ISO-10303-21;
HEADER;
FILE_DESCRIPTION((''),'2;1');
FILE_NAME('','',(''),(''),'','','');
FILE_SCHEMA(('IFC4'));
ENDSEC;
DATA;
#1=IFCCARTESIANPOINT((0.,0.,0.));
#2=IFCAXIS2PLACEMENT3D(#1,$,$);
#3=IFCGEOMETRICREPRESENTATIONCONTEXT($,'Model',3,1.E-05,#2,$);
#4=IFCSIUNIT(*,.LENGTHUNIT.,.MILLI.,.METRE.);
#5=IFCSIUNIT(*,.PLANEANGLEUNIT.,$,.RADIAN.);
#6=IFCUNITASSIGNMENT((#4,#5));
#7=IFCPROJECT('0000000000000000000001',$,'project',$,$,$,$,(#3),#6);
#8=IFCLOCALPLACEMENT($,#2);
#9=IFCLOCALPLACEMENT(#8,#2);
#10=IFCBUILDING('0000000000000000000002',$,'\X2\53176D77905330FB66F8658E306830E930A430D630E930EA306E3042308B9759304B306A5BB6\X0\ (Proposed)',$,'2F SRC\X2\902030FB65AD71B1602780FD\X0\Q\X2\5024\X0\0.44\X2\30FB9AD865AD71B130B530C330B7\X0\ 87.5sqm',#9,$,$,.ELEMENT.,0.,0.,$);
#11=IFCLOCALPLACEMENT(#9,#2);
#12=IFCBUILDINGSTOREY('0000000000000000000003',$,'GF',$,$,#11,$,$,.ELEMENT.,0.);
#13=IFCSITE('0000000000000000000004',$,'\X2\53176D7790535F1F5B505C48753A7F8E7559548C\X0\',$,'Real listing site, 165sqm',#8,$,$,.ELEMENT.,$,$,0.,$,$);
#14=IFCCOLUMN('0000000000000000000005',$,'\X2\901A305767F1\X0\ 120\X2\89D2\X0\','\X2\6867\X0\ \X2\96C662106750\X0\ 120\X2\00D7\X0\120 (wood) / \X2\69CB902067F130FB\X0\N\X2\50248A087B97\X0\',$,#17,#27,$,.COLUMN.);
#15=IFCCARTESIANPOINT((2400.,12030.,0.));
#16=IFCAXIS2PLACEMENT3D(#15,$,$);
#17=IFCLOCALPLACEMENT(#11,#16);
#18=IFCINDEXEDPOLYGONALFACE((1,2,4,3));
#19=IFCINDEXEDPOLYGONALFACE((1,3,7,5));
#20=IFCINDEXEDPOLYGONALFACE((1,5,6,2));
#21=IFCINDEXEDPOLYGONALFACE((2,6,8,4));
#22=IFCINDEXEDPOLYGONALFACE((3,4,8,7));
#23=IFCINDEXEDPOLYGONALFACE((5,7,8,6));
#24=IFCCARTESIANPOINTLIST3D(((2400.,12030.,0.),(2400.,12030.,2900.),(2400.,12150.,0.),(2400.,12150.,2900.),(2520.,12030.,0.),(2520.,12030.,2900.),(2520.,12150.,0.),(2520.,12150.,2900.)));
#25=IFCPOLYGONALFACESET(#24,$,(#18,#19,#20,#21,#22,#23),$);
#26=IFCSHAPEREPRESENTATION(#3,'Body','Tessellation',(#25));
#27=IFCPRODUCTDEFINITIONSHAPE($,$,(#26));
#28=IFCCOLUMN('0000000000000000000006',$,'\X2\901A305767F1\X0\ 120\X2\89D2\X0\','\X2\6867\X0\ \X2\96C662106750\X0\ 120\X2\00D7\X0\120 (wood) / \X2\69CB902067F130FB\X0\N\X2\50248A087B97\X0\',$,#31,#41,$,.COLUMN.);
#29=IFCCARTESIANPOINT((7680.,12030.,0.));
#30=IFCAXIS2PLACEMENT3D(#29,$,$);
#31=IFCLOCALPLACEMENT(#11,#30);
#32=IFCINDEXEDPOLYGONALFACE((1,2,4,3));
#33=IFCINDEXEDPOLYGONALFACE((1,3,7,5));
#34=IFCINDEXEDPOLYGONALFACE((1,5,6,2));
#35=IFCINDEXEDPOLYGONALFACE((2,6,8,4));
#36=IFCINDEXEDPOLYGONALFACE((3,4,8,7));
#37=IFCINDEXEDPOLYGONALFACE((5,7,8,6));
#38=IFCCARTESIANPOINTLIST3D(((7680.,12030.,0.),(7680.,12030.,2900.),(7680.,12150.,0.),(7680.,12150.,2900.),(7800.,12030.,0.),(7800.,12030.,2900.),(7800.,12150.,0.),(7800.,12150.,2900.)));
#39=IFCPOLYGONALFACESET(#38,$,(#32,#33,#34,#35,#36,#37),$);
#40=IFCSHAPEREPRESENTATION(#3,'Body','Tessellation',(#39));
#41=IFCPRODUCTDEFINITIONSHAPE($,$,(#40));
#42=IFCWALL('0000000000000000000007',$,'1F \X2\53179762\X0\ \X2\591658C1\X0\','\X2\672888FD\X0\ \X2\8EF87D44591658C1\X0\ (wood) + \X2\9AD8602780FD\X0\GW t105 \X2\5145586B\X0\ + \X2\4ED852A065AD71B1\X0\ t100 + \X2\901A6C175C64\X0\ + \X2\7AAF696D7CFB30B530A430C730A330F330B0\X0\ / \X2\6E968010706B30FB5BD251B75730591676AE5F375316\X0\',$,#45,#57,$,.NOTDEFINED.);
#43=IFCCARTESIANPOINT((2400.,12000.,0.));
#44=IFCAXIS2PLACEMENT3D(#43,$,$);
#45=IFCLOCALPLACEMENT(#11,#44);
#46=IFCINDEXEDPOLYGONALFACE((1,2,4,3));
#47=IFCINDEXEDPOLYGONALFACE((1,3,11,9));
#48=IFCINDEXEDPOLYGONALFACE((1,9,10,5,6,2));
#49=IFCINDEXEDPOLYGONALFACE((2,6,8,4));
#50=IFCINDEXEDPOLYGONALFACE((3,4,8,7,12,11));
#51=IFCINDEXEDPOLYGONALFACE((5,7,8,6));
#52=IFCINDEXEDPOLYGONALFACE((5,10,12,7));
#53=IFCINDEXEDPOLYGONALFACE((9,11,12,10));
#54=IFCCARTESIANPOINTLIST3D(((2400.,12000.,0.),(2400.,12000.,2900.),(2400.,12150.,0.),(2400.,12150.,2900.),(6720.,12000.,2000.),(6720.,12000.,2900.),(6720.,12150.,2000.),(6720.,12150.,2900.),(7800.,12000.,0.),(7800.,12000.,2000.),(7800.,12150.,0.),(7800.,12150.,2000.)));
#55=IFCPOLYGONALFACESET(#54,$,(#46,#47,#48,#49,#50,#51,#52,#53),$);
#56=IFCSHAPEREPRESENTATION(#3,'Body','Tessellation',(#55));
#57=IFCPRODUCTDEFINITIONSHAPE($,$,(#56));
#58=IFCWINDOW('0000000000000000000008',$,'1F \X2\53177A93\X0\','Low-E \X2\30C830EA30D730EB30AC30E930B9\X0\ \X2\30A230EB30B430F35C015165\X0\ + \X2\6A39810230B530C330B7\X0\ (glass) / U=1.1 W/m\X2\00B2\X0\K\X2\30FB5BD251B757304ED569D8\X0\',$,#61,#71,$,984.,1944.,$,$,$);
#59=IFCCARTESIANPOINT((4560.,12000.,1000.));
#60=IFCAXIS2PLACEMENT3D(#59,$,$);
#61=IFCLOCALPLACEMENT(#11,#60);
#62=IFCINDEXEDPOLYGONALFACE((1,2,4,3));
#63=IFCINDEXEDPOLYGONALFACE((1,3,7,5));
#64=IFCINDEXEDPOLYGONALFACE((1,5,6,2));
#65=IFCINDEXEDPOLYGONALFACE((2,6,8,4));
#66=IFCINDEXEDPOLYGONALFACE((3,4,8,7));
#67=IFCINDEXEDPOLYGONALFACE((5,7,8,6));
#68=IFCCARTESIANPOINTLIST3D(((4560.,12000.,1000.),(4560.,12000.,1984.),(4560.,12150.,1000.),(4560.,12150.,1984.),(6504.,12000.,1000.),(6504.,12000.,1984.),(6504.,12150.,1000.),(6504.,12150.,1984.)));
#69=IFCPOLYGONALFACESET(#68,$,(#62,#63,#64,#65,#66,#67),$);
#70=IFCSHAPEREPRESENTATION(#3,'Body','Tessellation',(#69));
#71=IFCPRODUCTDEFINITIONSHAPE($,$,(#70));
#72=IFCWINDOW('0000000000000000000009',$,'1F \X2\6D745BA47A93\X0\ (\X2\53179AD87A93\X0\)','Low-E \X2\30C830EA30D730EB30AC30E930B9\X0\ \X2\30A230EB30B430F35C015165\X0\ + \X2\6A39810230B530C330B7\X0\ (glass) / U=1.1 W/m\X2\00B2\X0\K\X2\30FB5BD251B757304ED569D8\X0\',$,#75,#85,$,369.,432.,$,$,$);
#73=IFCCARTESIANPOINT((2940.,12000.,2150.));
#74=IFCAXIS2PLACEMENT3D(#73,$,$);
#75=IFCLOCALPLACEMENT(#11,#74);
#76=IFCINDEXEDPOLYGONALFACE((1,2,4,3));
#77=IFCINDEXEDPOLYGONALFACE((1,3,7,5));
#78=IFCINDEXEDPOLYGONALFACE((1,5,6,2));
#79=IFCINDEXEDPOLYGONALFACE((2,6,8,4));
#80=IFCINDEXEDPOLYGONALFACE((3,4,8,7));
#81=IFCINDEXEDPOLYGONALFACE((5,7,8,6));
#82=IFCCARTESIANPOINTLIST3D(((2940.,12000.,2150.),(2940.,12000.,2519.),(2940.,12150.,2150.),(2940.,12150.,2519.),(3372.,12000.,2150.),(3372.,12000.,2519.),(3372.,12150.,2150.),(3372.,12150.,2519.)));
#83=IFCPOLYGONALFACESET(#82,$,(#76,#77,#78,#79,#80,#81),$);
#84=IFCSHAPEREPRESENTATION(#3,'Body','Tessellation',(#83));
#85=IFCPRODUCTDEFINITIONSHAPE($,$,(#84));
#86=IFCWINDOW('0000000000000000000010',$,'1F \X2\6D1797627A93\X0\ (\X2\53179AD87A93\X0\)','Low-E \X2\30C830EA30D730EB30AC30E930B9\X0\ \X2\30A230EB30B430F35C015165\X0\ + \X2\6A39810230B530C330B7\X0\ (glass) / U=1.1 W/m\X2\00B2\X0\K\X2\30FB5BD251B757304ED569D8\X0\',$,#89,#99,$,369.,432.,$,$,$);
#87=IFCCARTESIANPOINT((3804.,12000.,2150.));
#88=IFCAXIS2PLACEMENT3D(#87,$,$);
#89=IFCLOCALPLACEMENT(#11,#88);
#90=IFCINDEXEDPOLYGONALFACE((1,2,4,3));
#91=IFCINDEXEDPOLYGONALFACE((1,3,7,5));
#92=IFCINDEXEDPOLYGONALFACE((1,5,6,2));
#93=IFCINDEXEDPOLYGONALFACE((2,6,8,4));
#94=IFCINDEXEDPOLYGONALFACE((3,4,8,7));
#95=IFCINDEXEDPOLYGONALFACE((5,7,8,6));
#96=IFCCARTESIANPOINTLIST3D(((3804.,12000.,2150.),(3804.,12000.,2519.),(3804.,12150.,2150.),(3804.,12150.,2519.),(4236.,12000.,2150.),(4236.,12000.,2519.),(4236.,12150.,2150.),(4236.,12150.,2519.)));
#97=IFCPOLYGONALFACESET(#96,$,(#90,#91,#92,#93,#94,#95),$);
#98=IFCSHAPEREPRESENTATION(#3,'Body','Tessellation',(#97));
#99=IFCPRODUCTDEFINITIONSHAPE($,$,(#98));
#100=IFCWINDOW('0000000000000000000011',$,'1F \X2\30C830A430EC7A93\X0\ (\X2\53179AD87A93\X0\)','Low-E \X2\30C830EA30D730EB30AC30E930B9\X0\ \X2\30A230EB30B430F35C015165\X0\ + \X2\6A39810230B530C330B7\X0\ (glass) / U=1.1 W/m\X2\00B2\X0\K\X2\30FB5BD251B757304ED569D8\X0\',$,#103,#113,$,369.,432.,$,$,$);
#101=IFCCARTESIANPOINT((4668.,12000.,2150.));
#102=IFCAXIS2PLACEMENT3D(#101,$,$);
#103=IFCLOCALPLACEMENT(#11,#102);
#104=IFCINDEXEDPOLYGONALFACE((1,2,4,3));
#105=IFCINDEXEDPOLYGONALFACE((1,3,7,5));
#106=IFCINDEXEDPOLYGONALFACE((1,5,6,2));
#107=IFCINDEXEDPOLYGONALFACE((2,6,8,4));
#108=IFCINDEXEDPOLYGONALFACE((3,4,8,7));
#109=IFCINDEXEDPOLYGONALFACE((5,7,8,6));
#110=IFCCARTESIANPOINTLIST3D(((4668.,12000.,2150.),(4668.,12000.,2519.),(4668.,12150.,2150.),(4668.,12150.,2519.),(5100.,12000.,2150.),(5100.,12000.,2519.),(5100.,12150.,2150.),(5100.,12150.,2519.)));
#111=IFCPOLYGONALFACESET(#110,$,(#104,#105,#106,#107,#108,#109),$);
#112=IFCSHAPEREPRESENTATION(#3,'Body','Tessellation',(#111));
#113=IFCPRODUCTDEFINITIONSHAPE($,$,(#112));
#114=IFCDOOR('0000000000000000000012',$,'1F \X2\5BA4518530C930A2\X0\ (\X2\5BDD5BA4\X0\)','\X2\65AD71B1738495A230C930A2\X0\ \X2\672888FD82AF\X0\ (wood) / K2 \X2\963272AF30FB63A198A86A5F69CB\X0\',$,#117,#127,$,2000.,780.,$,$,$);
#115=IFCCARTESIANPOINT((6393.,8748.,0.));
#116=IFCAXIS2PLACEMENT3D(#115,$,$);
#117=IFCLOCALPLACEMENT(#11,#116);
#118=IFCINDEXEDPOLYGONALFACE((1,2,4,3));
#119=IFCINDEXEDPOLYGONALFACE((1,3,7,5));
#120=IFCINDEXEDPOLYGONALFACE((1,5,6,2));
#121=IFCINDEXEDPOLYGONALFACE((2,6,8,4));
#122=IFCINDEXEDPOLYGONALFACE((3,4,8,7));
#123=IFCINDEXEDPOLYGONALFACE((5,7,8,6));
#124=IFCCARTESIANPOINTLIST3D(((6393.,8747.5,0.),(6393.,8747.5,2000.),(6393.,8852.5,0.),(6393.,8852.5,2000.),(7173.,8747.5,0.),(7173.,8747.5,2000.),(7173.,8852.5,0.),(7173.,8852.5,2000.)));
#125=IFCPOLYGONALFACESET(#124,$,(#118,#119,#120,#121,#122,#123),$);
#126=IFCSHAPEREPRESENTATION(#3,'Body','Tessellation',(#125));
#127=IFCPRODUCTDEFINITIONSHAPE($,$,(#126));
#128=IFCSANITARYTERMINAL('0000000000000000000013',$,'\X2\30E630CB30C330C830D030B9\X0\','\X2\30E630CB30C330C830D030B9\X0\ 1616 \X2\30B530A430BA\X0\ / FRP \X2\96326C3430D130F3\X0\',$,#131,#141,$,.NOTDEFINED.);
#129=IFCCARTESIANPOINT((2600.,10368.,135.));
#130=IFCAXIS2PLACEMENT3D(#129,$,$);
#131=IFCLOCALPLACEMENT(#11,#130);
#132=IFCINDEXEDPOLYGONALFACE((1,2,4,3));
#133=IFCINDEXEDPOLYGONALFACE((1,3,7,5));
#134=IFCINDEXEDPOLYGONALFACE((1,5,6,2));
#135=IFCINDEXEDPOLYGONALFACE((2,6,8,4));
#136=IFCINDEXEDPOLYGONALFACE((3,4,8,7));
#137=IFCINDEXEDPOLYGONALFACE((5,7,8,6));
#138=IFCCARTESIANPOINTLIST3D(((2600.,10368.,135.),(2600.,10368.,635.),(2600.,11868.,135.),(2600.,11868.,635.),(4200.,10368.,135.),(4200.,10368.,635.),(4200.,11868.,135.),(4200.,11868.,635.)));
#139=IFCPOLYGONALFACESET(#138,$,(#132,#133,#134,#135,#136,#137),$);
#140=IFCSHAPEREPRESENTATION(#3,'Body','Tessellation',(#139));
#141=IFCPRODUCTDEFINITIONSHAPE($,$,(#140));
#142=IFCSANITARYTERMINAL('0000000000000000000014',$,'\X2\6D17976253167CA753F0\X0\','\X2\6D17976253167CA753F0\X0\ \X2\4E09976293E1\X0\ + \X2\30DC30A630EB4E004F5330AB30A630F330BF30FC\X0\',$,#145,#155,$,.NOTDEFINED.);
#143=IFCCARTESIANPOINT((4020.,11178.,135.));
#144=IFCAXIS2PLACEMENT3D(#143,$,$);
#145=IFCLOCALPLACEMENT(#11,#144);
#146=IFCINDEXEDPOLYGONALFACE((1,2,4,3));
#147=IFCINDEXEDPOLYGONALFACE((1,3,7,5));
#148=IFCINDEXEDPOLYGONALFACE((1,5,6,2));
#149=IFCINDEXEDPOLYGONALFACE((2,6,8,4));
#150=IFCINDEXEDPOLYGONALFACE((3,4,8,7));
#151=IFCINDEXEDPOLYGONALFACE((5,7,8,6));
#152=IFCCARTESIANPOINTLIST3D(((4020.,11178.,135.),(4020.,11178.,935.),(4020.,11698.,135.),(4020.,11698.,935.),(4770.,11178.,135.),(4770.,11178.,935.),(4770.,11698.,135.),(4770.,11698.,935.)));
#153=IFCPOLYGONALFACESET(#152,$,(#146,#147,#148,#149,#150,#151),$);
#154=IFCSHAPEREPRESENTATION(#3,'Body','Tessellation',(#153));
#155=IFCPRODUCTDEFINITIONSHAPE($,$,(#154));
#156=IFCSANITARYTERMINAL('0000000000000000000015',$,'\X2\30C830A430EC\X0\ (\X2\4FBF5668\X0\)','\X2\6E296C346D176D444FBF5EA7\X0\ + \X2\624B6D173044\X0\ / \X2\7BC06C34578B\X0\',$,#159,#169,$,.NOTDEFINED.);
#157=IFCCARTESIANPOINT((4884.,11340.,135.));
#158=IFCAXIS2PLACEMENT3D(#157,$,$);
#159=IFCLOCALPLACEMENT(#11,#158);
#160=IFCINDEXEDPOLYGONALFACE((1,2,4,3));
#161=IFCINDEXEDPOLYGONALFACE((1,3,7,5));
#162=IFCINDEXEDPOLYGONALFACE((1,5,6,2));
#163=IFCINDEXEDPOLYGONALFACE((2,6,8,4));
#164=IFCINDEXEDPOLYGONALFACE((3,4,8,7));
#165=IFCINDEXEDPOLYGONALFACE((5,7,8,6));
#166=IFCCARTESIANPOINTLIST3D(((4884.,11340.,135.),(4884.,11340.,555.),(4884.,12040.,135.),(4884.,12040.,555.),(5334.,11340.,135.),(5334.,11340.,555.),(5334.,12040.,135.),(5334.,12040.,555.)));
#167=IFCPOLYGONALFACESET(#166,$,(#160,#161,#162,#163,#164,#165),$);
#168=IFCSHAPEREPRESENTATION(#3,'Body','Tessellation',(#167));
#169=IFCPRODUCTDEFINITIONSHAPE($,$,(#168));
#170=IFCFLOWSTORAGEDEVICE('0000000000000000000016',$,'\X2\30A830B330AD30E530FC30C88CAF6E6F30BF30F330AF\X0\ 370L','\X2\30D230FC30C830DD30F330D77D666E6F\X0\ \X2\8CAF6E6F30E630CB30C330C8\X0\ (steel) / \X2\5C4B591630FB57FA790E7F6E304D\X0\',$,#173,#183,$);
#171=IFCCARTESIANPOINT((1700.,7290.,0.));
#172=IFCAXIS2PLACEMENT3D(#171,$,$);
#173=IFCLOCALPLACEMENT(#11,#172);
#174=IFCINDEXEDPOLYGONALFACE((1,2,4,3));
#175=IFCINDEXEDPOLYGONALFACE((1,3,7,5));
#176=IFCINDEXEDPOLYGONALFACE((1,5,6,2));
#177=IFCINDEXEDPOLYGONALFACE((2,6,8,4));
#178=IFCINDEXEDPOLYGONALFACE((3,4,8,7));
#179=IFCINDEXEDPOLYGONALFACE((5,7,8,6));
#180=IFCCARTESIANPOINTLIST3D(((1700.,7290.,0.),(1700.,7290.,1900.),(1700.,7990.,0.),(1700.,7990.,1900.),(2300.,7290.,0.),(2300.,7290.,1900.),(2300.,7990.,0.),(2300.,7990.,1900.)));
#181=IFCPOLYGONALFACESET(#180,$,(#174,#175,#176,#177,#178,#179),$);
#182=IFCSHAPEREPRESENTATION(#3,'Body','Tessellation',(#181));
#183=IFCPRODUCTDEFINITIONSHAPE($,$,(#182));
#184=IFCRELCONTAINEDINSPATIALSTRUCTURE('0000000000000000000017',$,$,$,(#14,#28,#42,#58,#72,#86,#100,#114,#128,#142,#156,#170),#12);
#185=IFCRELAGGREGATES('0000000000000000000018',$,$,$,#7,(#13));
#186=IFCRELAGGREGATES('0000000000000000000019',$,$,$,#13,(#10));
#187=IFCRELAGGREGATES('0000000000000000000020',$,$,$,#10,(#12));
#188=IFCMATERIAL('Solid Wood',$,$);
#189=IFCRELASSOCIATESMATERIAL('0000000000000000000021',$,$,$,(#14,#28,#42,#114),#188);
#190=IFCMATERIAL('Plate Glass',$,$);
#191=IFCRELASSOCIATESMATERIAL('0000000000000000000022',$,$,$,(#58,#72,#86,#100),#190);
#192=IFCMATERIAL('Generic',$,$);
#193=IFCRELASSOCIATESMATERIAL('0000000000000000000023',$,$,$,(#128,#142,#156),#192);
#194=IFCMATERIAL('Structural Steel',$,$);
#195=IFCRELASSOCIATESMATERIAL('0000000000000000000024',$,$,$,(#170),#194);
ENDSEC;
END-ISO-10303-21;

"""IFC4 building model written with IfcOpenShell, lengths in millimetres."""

from ifc_helpers import new_model, si_unit, frame, frame_2d, origin, place, context, project, spatial, rectangle, extrude, material, element, fill, save


model = new_model("IFC4")

# Units and contexts
model_context = context("Model", 3, precision=1e-05, world=origin())
ifc_project = project(units=[si_unit("LENGTHUNIT", "METRE", prefix="MILLI"), si_unit("PLANEANGLEUNIT", "RADIAN")], contexts=[model_context])

# Site, building, storey
site_placement = place(None, origin())
site = spatial("IfcSite", under=ifc_project, at=site_placement, Name="北海道弟子屈町美留和", ObjectType="Real listing site, 165sqm", CompositionType="ELEMENT", RefElevation=0.0)
building_placement = place(site_placement, origin())
building = spatial("IfcBuilding", under=site, at=building_placement, Name="北海道・書斎とライブラリのある静かな家 (Proposed)", ObjectType="2F SRC造・断熱性能Q値0.44・高断熱サッシ 87.5sqm", CompositionType="ELEMENT", ElevationOfRefHeight=0.0, ElevationOfTerrain=0.0)
storey_placement = place(building_placement, origin())
storey = spatial("IfcBuildingStorey", under=building, at=storey_placement, Name="GF", CompositionType="ELEMENT", Elevation=0.0)

# Columns
ifc_material_1 = material(Name="Solid Wood")
column_1_placement = place(storey_placement, frame((2400.0, 12030.0, 0.0)))
element("IfcColumn", 1, at=column_1_placement, inside=storey, material=ifc_material_1, Name="通し柱 120角", Description="桧 集成材 120×120 (wood) / 構造柱・N値計算", PredefinedType="COLUMN", context=model_context, shape_type="SweptSolid", body=[
    extrude(rectangle(XDim=120.0, YDim=120.0, at=frame_2d((60.0, 60.0))), frame((2400.0, 12030.0, 0.0)), (0.0, 0.0, 1.0), 2900.0),
])
column_2_placement = place(storey_placement, frame((7680.0, 12030.0, 0.0)))
element("IfcColumn", 2, at=column_2_placement, inside=storey, material=ifc_material_1, Name="通し柱 120角", Description="桧 集成材 120×120 (wood) / 構造柱・N値計算", PredefinedType="COLUMN", context=model_context, shape_type="SweptSolid", body=[
    extrude(rectangle(XDim=120.0, YDim=120.0, at=frame_2d((60.0, 60.0))), frame((7680.0, 12030.0, 0.0)), (0.0, 0.0, 1.0), 2900.0),
])

# Wall, openings, windows
wall_1_placement = place(storey_placement, frame((2400.0, 12000.0, 0.0)))
wall_1 = element("IfcWall", 3, at=wall_1_placement, inside=storey, material=ifc_material_1, Name="1F 北面 外壁", Description="木製 軸組外壁 (wood) + 高性能GW t105 充填 + 付加断熱 t100 + 通気層 + 窯業系サイディング / 準耐火・寒冷地外皮強化", PredefinedType="NOTDEFINED", context=model_context, shape_type="SweptSolid", body=[
    extrude(rectangle(XDim=5400.0, YDim=150.0, at=frame_2d((2700.0, 75.0))), frame((2400.0, 12000.0, 0.0)), (0.0, 0.0, 1.0), 2900.0),
])
opening_1_placement = place(storey_placement, frame((4560.0, 12000.0, 1000.0)))
opening_1 = element("IfcOpeningElement", 4, at=opening_1_placement, cuts=wall_1, PredefinedType="NOTDEFINED", context=model_context, shape_type="SweptSolid", body=[
    extrude(rectangle(XDim=1944.0, YDim=150.0, at=frame_2d((972.0, 75.0))), frame((4560.0, 12000.0, 1000.0)), (0.0, 0.0, 1.0), 984.0),
])
opening_2_placement = place(storey_placement, frame((2940.0, 12000.0, 2150.0)))
opening_2 = element("IfcOpeningElement", 5, at=opening_2_placement, cuts=wall_1, PredefinedType="NOTDEFINED", context=model_context, shape_type="SweptSolid", body=[
    extrude(rectangle(XDim=432.0, YDim=150.0, at=frame_2d((216.0, 75.0))), frame((2940.0, 12000.0, 2150.0)), (0.0, 0.0, 1.0), 369.0),
])
opening_3_placement = place(storey_placement, frame((3804.0, 12000.0, 2150.0)))
opening_3 = element("IfcOpeningElement", 6, at=opening_3_placement, cuts=wall_1, PredefinedType="NOTDEFINED", context=model_context, shape_type="SweptSolid", body=[
    extrude(rectangle(XDim=432.0, YDim=150.0, at=frame_2d((216.0, 75.0))), frame((3804.0, 12000.0, 2150.0)), (0.0, 0.0, 1.0), 369.0),
])
opening_4_placement = place(storey_placement, frame((4668.0, 12000.0, 2150.0)))
opening_4 = element("IfcOpeningElement", 7, at=opening_4_placement, cuts=wall_1, PredefinedType="NOTDEFINED", context=model_context, shape_type="SweptSolid", body=[
    extrude(rectangle(XDim=432.0, YDim=150.0, at=frame_2d((216.0, 75.0))), frame((4668.0, 12000.0, 2150.0)), (0.0, 0.0, 1.0), 369.0),
])
ifc_material_2 = material(Name="Plate Glass")
window_1_placement = place(storey_placement, frame((4560.0, 12000.0, 1000.0)))
window_1 = element("IfcWindow", 8, at=window_1_placement, inside=storey, material=ifc_material_2, Name="1F 北窓", Description="Low-E トリプルガラス アルゴン封入 + 樹脂サッシ (glass) / U=1.1 W/m²K・寒冷地仕様", OverallHeight=984.0, OverallWidth=1944.0, context=model_context, shape_type="SweptSolid", body=[
    extrude(rectangle(XDim=1944.0, YDim=150.0, at=frame_2d((972.0, 75.0))), frame((4560.0, 12000.0, 1000.0)), (0.0, 0.0, 1.0), 984.0),
])
fill(opening_1, window_1)
window_2_placement = place(storey_placement, frame((2940.0, 12000.0, 2150.0)))
window_2 = element("IfcWindow", 9, at=window_2_placement, inside=storey, material=ifc_material_2, Name="1F 浴室窓 (北高窓)", Description="Low-E トリプルガラス アルゴン封入 + 樹脂サッシ (glass) / U=1.1 W/m²K・寒冷地仕様", OverallHeight=369.0, OverallWidth=432.0, context=model_context, shape_type="SweptSolid", body=[
    extrude(rectangle(XDim=432.0, YDim=150.0, at=frame_2d((216.0, 75.0))), frame((2940.0, 12000.0, 2150.0)), (0.0, 0.0, 1.0), 369.0),
])
fill(opening_2, window_2)
window_3_placement = place(storey_placement, frame((3804.0, 12000.0, 2150.0)))
window_3 = element("IfcWindow", 10, at=window_3_placement, inside=storey, material=ifc_material_2, Name="1F 洗面窓 (北高窓)", Description="Low-E トリプルガラス アルゴン封入 + 樹脂サッシ (glass) / U=1.1 W/m²K・寒冷地仕様", OverallHeight=369.0, OverallWidth=432.0, context=model_context, shape_type="SweptSolid", body=[
    extrude(rectangle(XDim=432.0, YDim=150.0, at=frame_2d((216.0, 75.0))), frame((3804.0, 12000.0, 2150.0)), (0.0, 0.0, 1.0), 369.0),
])
fill(opening_3, window_3)
window_4_placement = place(storey_placement, frame((4668.0, 12000.0, 2150.0)))
window_4 = element("IfcWindow", 11, at=window_4_placement, inside=storey, material=ifc_material_2, Name="1F トイレ窓 (北高窓)", Description="Low-E トリプルガラス アルゴン封入 + 樹脂サッシ (glass) / U=1.1 W/m²K・寒冷地仕様", OverallHeight=369.0, OverallWidth=432.0, context=model_context, shape_type="SweptSolid", body=[
    extrude(rectangle(XDim=432.0, YDim=150.0, at=frame_2d((216.0, 75.0))), frame((4668.0, 12000.0, 2150.0)), (0.0, 0.0, 1.0), 369.0),
])
fill(opening_4, window_4)

# Door
door_1_placement = place(storey_placement, frame((6393.0, 8748.0, 0.0)))
element("IfcDoor", 12, at=door_1_placement, inside=storey, material=ifc_material_1, Name="1F 室内ドア (寝室)", Description="断熱玄関ドア 木製芯 (wood) / K2 防犯・採風機構", OverallHeight=2000.0, OverallWidth=780.0, context=model_context, shape_type="SweptSolid", body=[
    extrude(rectangle(XDim=780.0, YDim=105.0, at=frame_2d((390.0, 52.0))), frame((6393.0, 8748.0, 0.0)), (0.0, 0.0, 1.0), 2000.0),
])

# Sanitary terminals
ifc_material_3 = material(Name="Generic")
sanitary_terminal_1_placement = place(storey_placement, frame((2600.0, 10368.0, 135.0)))
element("IfcSanitaryTerminal", 13, at=sanitary_terminal_1_placement, inside=storey, material=ifc_material_3, Name="ユニットバス", Description="ユニットバス 1616 サイズ / FRP 防水パン", PredefinedType="NOTDEFINED", context=model_context, shape_type="SweptSolid", body=[
    extrude(rectangle(XDim=1600.0, YDim=1500.0, at=frame_2d((800.0, 750.0))), frame((2600.0, 10368.0, 135.0)), (0.0, 0.0, 1.0), 500.0),
])
sanitary_terminal_2_placement = place(storey_placement, frame((4020.0, 11178.0, 135.0)))
element("IfcSanitaryTerminal", 14, at=sanitary_terminal_2_placement, inside=storey, material=ifc_material_3, Name="洗面化粧台", Description="洗面化粧台 三面鏡 + ボウル一体カウンター", PredefinedType="NOTDEFINED", context=model_context, shape_type="SweptSolid", body=[
    extrude(rectangle(XDim=750.0, YDim=520.0, at=frame_2d((375.0, 260.0))), frame((4020.0, 11178.0, 135.0)), (0.0, 0.0, 1.0), 800.0),
])
sanitary_terminal_3_placement = place(storey_placement, frame((4884.0, 11340.0, 135.0)))
element("IfcSanitaryTerminal", 15, at=sanitary_terminal_3_placement, inside=storey, material=ifc_material_3, Name="トイレ (便器)", Description="温水洗浄便座 + 手洗い / 節水型", PredefinedType="NOTDEFINED", context=model_context, shape_type="SweptSolid", body=[
    extrude(rectangle(XDim=450.0, YDim=700.0, at=frame_2d((225.0, 350.0))), frame((4884.0, 11340.0, 135.0)), (0.0, 0.0, 1.0), 420.0),
])

# Flow storage device
ifc_material_4 = material(Name="Structural Steel")
flow_storage_device_placement = place(storey_placement, frame((1700.0, 7290.0, 0.0)))
element("IfcFlowStorageDevice", 16, at=flow_storage_device_placement, inside=storey, material=ifc_material_4, Name="エコキュート貯湯タンク 370L", Description="ヒートポンプ給湯 貯湯ユニット (steel) / 屋外・基礎置き", context=model_context, shape_type="SweptSolid", body=[
    extrude(rectangle(XDim=600.0, YDim=700.0, at=frame_2d((300.0, 350.0))), frame((1700.0, 7290.0, 0.0)), (0.0, 0.0, 1.0), 1900.0),
])

save(model, "model.ifc")
